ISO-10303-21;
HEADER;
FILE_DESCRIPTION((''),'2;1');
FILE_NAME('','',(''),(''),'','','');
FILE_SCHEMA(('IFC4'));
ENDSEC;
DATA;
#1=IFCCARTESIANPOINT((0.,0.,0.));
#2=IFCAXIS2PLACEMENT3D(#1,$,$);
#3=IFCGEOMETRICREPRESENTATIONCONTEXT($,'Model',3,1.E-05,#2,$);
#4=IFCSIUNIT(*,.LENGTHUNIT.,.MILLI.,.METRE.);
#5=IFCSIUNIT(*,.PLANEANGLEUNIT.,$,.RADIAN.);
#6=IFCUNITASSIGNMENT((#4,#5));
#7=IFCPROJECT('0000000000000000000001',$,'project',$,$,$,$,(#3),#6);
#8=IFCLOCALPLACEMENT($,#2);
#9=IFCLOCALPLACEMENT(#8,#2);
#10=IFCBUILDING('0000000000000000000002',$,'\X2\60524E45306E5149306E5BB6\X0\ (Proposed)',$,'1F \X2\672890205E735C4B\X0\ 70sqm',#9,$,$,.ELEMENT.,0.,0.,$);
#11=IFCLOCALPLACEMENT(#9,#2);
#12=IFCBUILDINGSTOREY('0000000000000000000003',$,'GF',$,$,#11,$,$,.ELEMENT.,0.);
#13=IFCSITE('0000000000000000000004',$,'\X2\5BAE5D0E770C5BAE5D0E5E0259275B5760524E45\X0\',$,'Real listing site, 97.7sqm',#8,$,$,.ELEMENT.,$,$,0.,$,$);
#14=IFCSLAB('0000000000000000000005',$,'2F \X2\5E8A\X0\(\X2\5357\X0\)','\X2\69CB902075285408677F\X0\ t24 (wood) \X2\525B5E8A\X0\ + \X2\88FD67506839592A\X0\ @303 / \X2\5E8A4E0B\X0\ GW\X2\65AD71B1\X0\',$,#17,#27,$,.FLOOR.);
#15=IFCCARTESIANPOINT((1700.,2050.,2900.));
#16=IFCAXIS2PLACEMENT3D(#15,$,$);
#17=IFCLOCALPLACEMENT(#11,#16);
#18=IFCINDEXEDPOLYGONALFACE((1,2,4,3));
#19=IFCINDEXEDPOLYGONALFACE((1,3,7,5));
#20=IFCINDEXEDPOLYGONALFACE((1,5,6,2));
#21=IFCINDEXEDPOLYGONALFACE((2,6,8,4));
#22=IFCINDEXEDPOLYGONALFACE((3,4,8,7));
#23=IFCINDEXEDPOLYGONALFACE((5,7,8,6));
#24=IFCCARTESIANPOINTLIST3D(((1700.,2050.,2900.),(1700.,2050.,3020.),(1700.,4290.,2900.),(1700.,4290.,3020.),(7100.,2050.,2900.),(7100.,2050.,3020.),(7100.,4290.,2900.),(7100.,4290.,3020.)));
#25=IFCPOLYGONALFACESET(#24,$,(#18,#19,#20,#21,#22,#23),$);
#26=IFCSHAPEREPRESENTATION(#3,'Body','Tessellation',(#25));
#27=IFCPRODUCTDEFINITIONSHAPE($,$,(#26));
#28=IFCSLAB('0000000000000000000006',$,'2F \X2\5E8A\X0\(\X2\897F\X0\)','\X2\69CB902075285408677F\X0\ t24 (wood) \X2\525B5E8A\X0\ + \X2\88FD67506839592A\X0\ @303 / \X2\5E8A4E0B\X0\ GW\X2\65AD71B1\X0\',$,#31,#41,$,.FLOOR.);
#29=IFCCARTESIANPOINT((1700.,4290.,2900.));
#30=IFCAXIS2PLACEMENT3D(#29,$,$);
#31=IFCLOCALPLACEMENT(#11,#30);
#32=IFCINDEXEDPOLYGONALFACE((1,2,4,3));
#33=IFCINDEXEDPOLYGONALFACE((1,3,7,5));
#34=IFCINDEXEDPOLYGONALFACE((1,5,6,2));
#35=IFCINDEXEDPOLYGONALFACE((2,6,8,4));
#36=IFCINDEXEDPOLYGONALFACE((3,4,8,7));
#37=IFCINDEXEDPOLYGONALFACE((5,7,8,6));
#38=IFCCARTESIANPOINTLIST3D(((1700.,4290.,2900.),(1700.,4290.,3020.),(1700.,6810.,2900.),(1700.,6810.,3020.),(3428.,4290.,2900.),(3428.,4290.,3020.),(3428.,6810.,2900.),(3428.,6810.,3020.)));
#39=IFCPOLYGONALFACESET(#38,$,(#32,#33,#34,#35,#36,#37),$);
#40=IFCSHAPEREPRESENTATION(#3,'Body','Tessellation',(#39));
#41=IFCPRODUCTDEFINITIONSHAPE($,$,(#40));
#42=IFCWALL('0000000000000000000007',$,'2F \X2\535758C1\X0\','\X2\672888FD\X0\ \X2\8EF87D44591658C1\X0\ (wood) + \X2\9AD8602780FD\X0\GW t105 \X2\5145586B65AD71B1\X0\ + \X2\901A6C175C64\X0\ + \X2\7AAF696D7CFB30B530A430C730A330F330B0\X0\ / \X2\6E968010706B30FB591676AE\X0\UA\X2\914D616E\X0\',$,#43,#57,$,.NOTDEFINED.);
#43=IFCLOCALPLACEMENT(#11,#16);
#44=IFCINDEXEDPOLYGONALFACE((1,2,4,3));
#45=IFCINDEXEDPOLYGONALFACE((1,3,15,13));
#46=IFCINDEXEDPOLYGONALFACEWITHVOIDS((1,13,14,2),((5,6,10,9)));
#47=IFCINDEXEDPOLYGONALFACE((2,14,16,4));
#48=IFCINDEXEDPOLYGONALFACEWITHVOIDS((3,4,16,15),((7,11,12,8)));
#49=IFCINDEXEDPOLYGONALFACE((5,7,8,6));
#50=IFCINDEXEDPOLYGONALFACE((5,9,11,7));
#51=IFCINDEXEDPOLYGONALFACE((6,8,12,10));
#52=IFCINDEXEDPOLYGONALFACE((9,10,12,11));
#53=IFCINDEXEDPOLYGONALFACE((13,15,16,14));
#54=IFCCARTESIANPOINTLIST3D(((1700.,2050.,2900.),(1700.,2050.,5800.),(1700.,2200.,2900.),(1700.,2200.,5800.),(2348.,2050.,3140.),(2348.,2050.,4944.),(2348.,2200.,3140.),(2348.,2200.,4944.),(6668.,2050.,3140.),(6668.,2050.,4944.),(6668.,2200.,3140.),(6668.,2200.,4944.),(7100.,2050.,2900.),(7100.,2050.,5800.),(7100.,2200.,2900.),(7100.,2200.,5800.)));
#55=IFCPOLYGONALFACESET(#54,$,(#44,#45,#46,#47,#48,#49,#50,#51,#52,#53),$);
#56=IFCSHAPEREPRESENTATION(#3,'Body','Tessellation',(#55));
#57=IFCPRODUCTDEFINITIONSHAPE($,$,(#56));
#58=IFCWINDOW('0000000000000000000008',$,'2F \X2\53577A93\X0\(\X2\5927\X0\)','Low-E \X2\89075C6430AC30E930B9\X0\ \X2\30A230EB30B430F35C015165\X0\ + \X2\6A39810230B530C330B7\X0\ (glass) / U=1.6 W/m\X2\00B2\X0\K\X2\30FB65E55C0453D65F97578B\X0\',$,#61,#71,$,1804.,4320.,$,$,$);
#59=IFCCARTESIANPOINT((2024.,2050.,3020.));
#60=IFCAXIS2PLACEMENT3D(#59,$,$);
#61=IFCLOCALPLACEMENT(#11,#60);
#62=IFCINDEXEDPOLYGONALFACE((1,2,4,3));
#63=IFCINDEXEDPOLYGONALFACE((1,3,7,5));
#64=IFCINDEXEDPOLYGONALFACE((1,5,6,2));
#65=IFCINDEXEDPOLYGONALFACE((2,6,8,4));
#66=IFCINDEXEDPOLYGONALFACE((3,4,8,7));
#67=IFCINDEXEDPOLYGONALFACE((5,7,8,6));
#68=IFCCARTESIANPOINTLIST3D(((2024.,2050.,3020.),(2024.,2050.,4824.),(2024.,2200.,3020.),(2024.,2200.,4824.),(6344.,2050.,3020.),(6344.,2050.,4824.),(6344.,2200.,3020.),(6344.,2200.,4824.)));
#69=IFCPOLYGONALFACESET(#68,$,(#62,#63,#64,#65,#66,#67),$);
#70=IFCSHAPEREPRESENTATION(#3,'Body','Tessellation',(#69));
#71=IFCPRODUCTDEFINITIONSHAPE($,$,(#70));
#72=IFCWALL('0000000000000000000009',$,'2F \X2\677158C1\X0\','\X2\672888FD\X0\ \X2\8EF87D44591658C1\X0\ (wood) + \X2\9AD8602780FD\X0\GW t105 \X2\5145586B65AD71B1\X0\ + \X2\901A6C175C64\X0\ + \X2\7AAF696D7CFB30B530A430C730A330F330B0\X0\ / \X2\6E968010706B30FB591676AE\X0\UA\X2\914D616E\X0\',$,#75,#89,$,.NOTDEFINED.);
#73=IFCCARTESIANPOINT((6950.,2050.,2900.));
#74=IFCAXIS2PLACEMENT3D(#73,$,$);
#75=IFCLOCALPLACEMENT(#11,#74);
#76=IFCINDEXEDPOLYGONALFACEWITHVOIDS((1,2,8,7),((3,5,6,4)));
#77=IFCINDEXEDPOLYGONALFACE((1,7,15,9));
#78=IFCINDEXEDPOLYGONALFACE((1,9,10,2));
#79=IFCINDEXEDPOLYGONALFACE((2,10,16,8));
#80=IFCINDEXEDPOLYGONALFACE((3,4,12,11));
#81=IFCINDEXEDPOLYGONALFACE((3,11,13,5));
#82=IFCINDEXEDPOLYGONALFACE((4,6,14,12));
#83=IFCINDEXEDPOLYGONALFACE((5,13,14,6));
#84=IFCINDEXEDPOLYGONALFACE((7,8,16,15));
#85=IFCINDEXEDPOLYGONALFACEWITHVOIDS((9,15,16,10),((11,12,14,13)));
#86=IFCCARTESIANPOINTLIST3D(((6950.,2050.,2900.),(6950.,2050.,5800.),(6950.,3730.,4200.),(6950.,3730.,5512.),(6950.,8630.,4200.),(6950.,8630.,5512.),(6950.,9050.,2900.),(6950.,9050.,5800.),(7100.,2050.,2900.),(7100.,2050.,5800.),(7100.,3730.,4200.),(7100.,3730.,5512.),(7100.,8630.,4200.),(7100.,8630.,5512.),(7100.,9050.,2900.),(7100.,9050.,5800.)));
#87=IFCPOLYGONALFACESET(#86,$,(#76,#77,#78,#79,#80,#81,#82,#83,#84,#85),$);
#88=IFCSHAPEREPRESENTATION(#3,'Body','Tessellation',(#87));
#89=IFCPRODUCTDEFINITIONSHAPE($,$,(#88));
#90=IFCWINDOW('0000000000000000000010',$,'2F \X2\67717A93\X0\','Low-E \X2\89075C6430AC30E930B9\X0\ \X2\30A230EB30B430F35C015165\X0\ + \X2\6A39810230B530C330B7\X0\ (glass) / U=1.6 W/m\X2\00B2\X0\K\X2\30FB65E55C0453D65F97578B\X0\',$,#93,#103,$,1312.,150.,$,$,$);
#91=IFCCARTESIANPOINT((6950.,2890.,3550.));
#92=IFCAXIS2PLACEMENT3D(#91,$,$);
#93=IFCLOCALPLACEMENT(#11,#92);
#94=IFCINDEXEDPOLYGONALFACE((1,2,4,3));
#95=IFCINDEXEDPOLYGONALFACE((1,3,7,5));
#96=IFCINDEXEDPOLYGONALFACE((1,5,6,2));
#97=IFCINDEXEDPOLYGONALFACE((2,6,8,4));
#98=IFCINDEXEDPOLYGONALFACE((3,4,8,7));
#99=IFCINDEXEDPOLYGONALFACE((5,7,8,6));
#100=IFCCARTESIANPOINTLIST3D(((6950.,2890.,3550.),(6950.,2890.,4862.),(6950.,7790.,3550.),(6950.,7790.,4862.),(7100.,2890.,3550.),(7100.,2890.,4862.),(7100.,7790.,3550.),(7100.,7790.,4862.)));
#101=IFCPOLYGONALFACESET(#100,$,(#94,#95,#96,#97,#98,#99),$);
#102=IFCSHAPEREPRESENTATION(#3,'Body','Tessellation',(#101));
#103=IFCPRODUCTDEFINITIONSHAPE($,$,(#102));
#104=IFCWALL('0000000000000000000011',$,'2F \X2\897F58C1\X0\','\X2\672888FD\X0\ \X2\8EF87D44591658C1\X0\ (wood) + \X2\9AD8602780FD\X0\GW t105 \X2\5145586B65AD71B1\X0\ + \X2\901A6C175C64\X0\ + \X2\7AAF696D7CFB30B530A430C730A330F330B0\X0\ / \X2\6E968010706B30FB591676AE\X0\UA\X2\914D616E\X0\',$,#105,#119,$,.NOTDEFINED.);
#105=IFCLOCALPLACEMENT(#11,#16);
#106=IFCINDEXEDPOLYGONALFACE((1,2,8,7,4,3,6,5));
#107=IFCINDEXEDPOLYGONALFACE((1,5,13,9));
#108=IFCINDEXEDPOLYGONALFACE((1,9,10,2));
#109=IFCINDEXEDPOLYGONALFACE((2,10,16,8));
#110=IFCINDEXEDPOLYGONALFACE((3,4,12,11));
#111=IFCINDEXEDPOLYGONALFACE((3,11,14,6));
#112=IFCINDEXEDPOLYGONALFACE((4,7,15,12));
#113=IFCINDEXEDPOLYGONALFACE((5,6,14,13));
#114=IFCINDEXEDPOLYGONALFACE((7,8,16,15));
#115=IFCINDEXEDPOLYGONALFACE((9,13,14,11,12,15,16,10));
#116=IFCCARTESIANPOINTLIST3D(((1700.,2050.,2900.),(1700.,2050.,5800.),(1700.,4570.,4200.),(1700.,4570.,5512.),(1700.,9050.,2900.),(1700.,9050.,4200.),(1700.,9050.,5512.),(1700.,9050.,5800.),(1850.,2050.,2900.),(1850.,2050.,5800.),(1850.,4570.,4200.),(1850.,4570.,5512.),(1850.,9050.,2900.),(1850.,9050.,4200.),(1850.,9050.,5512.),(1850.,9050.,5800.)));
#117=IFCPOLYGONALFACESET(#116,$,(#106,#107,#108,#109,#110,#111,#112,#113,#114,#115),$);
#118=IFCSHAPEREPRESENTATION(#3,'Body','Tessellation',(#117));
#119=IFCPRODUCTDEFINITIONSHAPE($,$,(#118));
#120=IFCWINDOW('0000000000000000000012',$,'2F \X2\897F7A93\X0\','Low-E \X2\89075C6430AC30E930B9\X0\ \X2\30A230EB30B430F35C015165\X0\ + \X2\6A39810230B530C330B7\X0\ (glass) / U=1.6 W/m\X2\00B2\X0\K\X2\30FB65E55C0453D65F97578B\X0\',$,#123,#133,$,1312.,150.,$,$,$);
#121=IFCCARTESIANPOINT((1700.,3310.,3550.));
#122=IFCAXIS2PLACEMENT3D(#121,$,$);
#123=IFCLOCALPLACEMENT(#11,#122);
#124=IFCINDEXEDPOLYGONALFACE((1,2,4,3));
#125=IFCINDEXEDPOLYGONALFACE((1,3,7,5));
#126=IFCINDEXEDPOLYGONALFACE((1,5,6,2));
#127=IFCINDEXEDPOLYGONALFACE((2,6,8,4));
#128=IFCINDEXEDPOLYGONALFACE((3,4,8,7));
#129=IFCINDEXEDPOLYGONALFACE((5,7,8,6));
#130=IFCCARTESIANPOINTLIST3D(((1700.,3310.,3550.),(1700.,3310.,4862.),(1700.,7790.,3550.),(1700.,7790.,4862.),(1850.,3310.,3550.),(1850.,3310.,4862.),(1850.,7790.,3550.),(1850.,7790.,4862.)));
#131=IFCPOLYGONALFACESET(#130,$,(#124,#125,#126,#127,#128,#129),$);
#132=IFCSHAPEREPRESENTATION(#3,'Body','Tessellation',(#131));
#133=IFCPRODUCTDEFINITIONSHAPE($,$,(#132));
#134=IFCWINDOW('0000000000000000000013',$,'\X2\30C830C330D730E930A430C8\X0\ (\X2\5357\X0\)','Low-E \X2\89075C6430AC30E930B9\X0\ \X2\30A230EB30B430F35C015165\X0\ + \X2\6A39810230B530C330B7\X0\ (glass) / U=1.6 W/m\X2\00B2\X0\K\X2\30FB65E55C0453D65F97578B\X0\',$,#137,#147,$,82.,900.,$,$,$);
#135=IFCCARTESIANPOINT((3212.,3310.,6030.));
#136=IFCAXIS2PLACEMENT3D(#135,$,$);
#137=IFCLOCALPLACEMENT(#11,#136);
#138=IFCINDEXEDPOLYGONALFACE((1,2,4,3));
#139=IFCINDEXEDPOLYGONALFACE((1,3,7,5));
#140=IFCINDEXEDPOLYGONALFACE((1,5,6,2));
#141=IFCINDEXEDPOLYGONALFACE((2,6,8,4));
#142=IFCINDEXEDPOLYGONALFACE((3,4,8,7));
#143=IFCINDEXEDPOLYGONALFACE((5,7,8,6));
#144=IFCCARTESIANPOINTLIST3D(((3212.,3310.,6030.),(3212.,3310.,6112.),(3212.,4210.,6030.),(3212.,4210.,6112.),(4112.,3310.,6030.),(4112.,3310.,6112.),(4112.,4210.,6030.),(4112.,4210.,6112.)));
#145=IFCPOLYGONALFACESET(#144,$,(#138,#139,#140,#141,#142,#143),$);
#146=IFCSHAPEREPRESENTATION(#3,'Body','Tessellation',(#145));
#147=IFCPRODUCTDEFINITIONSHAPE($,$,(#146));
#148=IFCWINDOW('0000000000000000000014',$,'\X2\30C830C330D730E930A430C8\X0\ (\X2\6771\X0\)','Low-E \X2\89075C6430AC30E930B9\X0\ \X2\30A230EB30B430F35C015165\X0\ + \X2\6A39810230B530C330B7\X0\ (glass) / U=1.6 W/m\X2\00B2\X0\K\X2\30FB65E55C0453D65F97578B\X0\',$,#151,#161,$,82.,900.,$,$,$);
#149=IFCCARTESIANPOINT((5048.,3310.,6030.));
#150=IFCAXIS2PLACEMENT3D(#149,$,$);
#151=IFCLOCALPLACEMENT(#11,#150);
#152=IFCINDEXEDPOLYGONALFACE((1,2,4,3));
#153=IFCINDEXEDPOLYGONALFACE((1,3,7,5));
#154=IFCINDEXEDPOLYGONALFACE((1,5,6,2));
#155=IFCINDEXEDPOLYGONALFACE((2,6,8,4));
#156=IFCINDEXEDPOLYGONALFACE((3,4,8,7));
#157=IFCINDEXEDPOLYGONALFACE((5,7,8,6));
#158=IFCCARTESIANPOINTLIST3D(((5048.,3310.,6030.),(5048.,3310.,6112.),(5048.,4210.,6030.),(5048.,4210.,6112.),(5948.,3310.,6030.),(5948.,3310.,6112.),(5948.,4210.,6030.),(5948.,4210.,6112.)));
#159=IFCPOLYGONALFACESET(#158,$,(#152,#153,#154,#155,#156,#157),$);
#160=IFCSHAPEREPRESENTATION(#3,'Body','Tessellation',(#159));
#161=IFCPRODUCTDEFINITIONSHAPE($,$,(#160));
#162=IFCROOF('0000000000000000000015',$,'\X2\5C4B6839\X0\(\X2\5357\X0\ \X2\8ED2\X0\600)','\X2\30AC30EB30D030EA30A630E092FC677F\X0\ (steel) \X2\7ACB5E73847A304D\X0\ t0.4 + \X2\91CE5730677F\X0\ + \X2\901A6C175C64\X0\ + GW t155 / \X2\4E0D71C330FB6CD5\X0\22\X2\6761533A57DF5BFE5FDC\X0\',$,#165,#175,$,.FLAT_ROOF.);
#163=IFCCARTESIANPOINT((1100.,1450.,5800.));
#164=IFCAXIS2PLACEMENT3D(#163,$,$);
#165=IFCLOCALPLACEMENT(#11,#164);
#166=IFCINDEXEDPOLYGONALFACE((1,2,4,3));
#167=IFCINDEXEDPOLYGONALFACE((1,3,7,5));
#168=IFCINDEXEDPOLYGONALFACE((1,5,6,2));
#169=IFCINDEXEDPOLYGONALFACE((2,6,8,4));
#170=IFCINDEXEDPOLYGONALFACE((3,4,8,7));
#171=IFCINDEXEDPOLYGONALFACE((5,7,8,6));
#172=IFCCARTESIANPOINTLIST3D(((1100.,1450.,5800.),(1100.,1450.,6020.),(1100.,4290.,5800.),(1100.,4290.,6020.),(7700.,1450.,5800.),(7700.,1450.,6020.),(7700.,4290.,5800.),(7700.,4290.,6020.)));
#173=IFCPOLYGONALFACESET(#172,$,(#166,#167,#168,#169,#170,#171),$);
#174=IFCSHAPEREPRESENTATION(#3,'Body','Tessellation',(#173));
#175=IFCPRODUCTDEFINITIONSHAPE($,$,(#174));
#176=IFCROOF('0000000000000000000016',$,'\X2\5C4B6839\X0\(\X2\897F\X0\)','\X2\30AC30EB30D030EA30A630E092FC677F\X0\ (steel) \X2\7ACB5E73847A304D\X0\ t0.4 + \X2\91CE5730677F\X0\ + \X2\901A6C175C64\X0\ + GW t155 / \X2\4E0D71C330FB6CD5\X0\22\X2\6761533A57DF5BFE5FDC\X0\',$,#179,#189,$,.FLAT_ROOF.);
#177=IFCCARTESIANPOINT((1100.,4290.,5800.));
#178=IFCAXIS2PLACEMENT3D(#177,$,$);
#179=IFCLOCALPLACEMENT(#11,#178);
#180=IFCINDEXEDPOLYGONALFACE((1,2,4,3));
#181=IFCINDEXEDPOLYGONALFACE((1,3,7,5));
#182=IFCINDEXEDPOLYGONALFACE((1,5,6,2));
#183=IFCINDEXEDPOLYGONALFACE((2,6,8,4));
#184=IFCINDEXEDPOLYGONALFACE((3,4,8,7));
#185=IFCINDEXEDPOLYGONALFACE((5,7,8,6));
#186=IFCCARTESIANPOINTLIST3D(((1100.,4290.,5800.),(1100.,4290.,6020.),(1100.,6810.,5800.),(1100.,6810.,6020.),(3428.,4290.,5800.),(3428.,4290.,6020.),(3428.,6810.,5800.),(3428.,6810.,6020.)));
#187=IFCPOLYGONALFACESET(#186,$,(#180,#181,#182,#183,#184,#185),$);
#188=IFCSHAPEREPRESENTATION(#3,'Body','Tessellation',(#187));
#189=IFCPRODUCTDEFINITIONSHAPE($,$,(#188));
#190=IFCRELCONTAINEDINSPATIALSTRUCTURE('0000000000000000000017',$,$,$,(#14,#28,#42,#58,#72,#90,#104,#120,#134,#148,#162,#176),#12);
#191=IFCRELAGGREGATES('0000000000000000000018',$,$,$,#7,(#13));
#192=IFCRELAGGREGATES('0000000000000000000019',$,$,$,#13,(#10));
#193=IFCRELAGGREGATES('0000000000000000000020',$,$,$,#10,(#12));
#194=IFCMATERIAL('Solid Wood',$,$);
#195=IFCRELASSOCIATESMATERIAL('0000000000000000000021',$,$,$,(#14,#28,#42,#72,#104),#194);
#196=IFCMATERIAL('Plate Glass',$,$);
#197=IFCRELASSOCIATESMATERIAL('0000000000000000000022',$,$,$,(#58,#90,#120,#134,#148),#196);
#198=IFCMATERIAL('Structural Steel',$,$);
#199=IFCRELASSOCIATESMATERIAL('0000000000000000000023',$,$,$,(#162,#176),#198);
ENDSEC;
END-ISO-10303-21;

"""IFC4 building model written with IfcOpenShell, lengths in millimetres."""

from ifc_helpers import new_model, si_unit, frame, frame_2d, origin, place, context, project, spatial, rectangle, extrude, material, element, fill, save


model = new_model("IFC4")

# Units and contexts
model_context = context("Model", 3, precision=1e-05, world=origin())
ifc_project = project(units=[si_unit("LENGTHUNIT", "METRE", prefix="MILLI"), si_unit("PLANEANGLEUNIT", "RADIAN")], contexts=[model_context])

# Site, building, storey
site_placement = place(None, origin())
site = spatial("IfcSite", under=ifc_project, at=site_placement, Name="宮崎県宮崎市大字恒久", ObjectType="Real listing site, 97.7sqm", CompositionType="ELEMENT", RefElevation=0.0)
building_placement = place(site_placement, origin())
building = spatial("IfcBuilding", under=site, at=building_placement, Name="恒久の光の家 (Proposed)", ObjectType="1F 木造平屋 70sqm", CompositionType="ELEMENT", ElevationOfRefHeight=0.0, ElevationOfTerrain=0.0)
storey_placement = place(building_placement, origin())
storey = spatial("IfcBuildingStorey", under=building, at=storey_placement, Name="GF", CompositionType="ELEMENT", Elevation=0.0)

# Slabs
ifc_material_1 = material(Name="Solid Wood")
slab_1_placement = place(storey_placement, frame((1700.0, 2050.0, 2900.0)))
element("IfcSlab", 1, at=slab_1_placement, inside=storey, material=ifc_material_1, Name="2F 床(南)", Description="構造用合板 t24 (wood) 剛床 + 製材根太 @303 / 床下 GW断熱", PredefinedType="FLOOR", context=model_context, shape_type="SweptSolid", body=[
    extrude(rectangle(XDim=5400.0, YDim=2240.0, at=frame_2d((2700.0, 1120.0))), frame((1700.0, 2050.0, 2900.0)), (0.0, 0.0, 1.0), 120.0),
])
slab_2_placement = place(storey_placement, frame((1700.0, 4290.0, 2900.0)))
element("IfcSlab", 2, at=slab_2_placement, inside=storey, material=ifc_material_1, Name="2F 床(西)", Description="構造用合板 t24 (wood) 剛床 + 製材根太 @303 / 床下 GW断熱", PredefinedType="FLOOR", context=model_context, shape_type="SweptSolid", body=[
    extrude(rectangle(XDim=1728.0, YDim=2520.0, at=frame_2d((864.0, 1260.0))), frame((1700.0, 4290.0, 2900.0)), (0.0, 0.0, 1.0), 120.0),
])

# Walls, openings, windows
wall_1_placement = place(storey_placement, frame((1700.0, 2050.0, 2900.0)))
wall_1 = element("IfcWall", 3, at=wall_1_placement, inside=storey, material=ifc_material_1, Name="2F 南壁", Description="木製 軸組外壁 (wood) + 高性能GW t105 充填断熱 + 通気層 + 窯業系サイディング / 準耐火・外皮UA配慮", PredefinedType="NOTDEFINED", context=model_context, shape_type="SweptSolid", body=[
    extrude(rectangle(XDim=5400.0, YDim=150.0, at=frame_2d((2700.0, 75.0))), frame((1700.0, 2050.0, 2900.0)), (0.0, 0.0, 1.0), 2900.0),
])
opening_1_placement = place(storey_placement, frame((2024.0, 2050.0, 3020.0)))
opening_1 = element("IfcOpeningElement", 4, at=opening_1_placement, cuts=wall_1, PredefinedType="NOTDEFINED", context=model_context, shape_type="SweptSolid", body=[
    extrude(rectangle(XDim=4320.0, YDim=150.0, at=frame_2d((2160.0, 75.0))), frame((2024.0, 2050.0, 3020.0)), (0.0, 0.0, 1.0), 1804.0),
])
ifc_material_2 = material(Name="Plate Glass")
window_1_placement = place(storey_placement, frame((2024.0, 2050.0, 3020.0)))
window_1 = element("IfcWindow", 5, at=window_1_placement, inside=storey, material=ifc_material_2, Name="2F 南窓(大)", Description="Low-E 複層ガラス アルゴン封入 + 樹脂サッシ (glass) / U=1.6 W/m²K・日射取得型", OverallHeight=1804.0, OverallWidth=4320.0, context=model_context, shape_type="SweptSolid", body=[
    extrude(rectangle(XDim=4320.0, YDim=150.0, at=frame_2d((2160.0, 75.0))), frame((2024.0, 2050.0, 3020.0)), (0.0, 0.0, 1.0), 1804.0),
])
fill(opening_1, window_1)
wall_2_placement = place(storey_placement, frame((6950.0, 2050.0, 2900.0)))
wall_2 = element("IfcWall", 6, at=wall_2_placement, inside=storey, material=ifc_material_1, Name="2F 東壁", Description="木製 軸組外壁 (wood) + 高性能GW t105 充填断熱 + 通気層 + 窯業系サイディング / 準耐火・外皮UA配慮", PredefinedType="NOTDEFINED", context=model_context, shape_type="SweptSolid", body=[
    extrude(rectangle(XDim=150.0, YDim=7000.0, at=frame_2d((75.0, 3500.0))), frame((6950.0, 2050.0, 2900.0)), (0.0, 0.0, 1.0), 2900.0),
])
opening_2_placement = place(storey_placement, frame((6950.0, 2890.0, 3550.0)))
opening_2 = element("IfcOpeningElement", 7, at=opening_2_placement, cuts=wall_2, PredefinedType="NOTDEFINED", context=model_context, shape_type="SweptSolid", body=[
    extrude(rectangle(XDim=150.0, YDim=4900.0, at=frame_2d((75.0, 2450.0))), frame((6950.0, 2890.0, 3550.0)), (0.0, 0.0, 1.0), 1312.0),
])
window_2_placement = place(storey_placement, frame((6950.0, 2890.0, 3550.0)))
window_2 = element("IfcWindow", 8, at=window_2_placement, inside=storey, material=ifc_material_2, Name="2F 東窓", Description="Low-E 複層ガラス アルゴン封入 + 樹脂サッシ (glass) / U=1.6 W/m²K・日射取得型", OverallHeight=1312.0, OverallWidth=150.0, context=model_context, shape_type="SweptSolid", body=[
    extrude(rectangle(XDim=150.0, YDim=4900.0, at=frame_2d((75.0, 2450.0))), frame((6950.0, 2890.0, 3550.0)), (0.0, 0.0, 1.0), 1312.0),
])
fill(opening_2, window_2)
wall_3_placement = place(storey_placement, frame((1700.0, 2050.0, 2900.0)))
wall_3 = element("IfcWall", 9, at=wall_3_placement, inside=storey, material=ifc_material_1, Name="2F 西壁", Description="木製 軸組外壁 (wood) + 高性能GW t105 充填断熱 + 通気層 + 窯業系サイディング / 準耐火・外皮UA配慮", PredefinedType="NOTDEFINED", context=model_context, shape_type="SweptSolid", body=[
    extrude(rectangle(XDim=150.0, YDim=7000.0, at=frame_2d((75.0, 3500.0))), frame((1700.0, 2050.0, 2900.0)), (0.0, 0.0, 1.0), 2900.0),
])
opening_3_placement = place(storey_placement, frame((1700.0, 3310.0, 3550.0)))
opening_3 = element("IfcOpeningElement", 10, at=opening_3_placement, cuts=wall_3, PredefinedType="NOTDEFINED", context=model_context, shape_type="SweptSolid", body=[
    extrude(rectangle(XDim=150.0, YDim=4480.0, at=frame_2d((75.0, 2240.0))), frame((1700.0, 3310.0, 3550.0)), (0.0, 0.0, 1.0), 1312.0),
])
window_3_placement = place(storey_placement, frame((1700.0, 3310.0, 3550.0)))
window_3 = element("IfcWindow", 11, at=window_3_placement, inside=storey, material=ifc_material_2, Name="2F 西窓", Description="Low-E 複層ガラス アルゴン封入 + 樹脂サッシ (glass) / U=1.6 W/m²K・日射取得型", OverallHeight=1312.0, OverallWidth=150.0, context=model_context, shape_type="SweptSolid", body=[
    extrude(rectangle(XDim=150.0, YDim=4480.0, at=frame_2d((75.0, 2240.0))), frame((1700.0, 3310.0, 3550.0)), (0.0, 0.0, 1.0), 1312.0),
])
fill(opening_3, window_3)

# Windows
window_4_placement = place(storey_placement, frame((3212.0, 3310.0, 6030.0)))
element("IfcWindow", 12, at=window_4_placement, inside=storey, material=ifc_material_2, Name="トップライト (南)", Description="Low-E 複層ガラス アルゴン封入 + 樹脂サッシ (glass) / U=1.6 W/m²K・日射取得型", OverallHeight=82.0, OverallWidth=900.0, context=model_context, shape_type="SweptSolid", body=[
    extrude(rectangle(XDim=900.0, YDim=900.0, at=frame_2d((450.0, 450.0))), frame((3212.0, 3310.0, 6030.0)), (0.0, 0.0, 1.0), 82.0),
])
window_5_placement = place(storey_placement, frame((5048.0, 3310.0, 6030.0)))
element("IfcWindow", 13, at=window_5_placement, inside=storey, material=ifc_material_2, Name="トップライト (東)", Description="Low-E 複層ガラス アルゴン封入 + 樹脂サッシ (glass) / U=1.6 W/m²K・日射取得型", OverallHeight=82.0, OverallWidth=900.0, context=model_context, shape_type="SweptSolid", body=[
    extrude(rectangle(XDim=900.0, YDim=900.0, at=frame_2d((450.0, 450.0))), frame((5048.0, 3310.0, 6030.0)), (0.0, 0.0, 1.0), 82.0),
])

# Roofs
ifc_material_3 = material(Name="Structural Steel")
roof_1_placement = place(storey_placement, frame((1100.0, 1450.0, 5800.0)))
element("IfcRoof", 14, at=roof_1_placement, inside=storey, material=ifc_material_3, Name="屋根(南 軒600)", Description="ガルバリウム鋼板 (steel) 立平葺き t0.4 + 野地板 + 通気層 + GW t155 / 不燃・法22条区域対応", PredefinedType="FLAT_ROOF", context=model_context, shape_type="SweptSolid", body=[
    extrude(rectangle(XDim=6600.0, YDim=2840.0, at=frame_2d((3300.0, 1420.0))), frame((1100.0, 1450.0, 5800.0)), (0.0, 0.0, 1.0), 220.0),
])
roof_2_placement = place(storey_placement, frame((1100.0, 4290.0, 5800.0)))
element("IfcRoof", 15, at=roof_2_placement, inside=storey, material=ifc_material_3, Name="屋根(西)", Description="ガルバリウム鋼板 (steel) 立平葺き t0.4 + 野地板 + 通気層 + GW t155 / 不燃・法22条区域対応", PredefinedType="FLAT_ROOF", context=model_context, shape_type="SweptSolid", body=[
    extrude(rectangle(XDim=2328.0, YDim=2520.0, at=frame_2d((1164.0, 1260.0))), frame((1100.0, 4290.0, 5800.0)), (0.0, 0.0, 1.0), 220.0),
])

save(model, "model.ifc")
